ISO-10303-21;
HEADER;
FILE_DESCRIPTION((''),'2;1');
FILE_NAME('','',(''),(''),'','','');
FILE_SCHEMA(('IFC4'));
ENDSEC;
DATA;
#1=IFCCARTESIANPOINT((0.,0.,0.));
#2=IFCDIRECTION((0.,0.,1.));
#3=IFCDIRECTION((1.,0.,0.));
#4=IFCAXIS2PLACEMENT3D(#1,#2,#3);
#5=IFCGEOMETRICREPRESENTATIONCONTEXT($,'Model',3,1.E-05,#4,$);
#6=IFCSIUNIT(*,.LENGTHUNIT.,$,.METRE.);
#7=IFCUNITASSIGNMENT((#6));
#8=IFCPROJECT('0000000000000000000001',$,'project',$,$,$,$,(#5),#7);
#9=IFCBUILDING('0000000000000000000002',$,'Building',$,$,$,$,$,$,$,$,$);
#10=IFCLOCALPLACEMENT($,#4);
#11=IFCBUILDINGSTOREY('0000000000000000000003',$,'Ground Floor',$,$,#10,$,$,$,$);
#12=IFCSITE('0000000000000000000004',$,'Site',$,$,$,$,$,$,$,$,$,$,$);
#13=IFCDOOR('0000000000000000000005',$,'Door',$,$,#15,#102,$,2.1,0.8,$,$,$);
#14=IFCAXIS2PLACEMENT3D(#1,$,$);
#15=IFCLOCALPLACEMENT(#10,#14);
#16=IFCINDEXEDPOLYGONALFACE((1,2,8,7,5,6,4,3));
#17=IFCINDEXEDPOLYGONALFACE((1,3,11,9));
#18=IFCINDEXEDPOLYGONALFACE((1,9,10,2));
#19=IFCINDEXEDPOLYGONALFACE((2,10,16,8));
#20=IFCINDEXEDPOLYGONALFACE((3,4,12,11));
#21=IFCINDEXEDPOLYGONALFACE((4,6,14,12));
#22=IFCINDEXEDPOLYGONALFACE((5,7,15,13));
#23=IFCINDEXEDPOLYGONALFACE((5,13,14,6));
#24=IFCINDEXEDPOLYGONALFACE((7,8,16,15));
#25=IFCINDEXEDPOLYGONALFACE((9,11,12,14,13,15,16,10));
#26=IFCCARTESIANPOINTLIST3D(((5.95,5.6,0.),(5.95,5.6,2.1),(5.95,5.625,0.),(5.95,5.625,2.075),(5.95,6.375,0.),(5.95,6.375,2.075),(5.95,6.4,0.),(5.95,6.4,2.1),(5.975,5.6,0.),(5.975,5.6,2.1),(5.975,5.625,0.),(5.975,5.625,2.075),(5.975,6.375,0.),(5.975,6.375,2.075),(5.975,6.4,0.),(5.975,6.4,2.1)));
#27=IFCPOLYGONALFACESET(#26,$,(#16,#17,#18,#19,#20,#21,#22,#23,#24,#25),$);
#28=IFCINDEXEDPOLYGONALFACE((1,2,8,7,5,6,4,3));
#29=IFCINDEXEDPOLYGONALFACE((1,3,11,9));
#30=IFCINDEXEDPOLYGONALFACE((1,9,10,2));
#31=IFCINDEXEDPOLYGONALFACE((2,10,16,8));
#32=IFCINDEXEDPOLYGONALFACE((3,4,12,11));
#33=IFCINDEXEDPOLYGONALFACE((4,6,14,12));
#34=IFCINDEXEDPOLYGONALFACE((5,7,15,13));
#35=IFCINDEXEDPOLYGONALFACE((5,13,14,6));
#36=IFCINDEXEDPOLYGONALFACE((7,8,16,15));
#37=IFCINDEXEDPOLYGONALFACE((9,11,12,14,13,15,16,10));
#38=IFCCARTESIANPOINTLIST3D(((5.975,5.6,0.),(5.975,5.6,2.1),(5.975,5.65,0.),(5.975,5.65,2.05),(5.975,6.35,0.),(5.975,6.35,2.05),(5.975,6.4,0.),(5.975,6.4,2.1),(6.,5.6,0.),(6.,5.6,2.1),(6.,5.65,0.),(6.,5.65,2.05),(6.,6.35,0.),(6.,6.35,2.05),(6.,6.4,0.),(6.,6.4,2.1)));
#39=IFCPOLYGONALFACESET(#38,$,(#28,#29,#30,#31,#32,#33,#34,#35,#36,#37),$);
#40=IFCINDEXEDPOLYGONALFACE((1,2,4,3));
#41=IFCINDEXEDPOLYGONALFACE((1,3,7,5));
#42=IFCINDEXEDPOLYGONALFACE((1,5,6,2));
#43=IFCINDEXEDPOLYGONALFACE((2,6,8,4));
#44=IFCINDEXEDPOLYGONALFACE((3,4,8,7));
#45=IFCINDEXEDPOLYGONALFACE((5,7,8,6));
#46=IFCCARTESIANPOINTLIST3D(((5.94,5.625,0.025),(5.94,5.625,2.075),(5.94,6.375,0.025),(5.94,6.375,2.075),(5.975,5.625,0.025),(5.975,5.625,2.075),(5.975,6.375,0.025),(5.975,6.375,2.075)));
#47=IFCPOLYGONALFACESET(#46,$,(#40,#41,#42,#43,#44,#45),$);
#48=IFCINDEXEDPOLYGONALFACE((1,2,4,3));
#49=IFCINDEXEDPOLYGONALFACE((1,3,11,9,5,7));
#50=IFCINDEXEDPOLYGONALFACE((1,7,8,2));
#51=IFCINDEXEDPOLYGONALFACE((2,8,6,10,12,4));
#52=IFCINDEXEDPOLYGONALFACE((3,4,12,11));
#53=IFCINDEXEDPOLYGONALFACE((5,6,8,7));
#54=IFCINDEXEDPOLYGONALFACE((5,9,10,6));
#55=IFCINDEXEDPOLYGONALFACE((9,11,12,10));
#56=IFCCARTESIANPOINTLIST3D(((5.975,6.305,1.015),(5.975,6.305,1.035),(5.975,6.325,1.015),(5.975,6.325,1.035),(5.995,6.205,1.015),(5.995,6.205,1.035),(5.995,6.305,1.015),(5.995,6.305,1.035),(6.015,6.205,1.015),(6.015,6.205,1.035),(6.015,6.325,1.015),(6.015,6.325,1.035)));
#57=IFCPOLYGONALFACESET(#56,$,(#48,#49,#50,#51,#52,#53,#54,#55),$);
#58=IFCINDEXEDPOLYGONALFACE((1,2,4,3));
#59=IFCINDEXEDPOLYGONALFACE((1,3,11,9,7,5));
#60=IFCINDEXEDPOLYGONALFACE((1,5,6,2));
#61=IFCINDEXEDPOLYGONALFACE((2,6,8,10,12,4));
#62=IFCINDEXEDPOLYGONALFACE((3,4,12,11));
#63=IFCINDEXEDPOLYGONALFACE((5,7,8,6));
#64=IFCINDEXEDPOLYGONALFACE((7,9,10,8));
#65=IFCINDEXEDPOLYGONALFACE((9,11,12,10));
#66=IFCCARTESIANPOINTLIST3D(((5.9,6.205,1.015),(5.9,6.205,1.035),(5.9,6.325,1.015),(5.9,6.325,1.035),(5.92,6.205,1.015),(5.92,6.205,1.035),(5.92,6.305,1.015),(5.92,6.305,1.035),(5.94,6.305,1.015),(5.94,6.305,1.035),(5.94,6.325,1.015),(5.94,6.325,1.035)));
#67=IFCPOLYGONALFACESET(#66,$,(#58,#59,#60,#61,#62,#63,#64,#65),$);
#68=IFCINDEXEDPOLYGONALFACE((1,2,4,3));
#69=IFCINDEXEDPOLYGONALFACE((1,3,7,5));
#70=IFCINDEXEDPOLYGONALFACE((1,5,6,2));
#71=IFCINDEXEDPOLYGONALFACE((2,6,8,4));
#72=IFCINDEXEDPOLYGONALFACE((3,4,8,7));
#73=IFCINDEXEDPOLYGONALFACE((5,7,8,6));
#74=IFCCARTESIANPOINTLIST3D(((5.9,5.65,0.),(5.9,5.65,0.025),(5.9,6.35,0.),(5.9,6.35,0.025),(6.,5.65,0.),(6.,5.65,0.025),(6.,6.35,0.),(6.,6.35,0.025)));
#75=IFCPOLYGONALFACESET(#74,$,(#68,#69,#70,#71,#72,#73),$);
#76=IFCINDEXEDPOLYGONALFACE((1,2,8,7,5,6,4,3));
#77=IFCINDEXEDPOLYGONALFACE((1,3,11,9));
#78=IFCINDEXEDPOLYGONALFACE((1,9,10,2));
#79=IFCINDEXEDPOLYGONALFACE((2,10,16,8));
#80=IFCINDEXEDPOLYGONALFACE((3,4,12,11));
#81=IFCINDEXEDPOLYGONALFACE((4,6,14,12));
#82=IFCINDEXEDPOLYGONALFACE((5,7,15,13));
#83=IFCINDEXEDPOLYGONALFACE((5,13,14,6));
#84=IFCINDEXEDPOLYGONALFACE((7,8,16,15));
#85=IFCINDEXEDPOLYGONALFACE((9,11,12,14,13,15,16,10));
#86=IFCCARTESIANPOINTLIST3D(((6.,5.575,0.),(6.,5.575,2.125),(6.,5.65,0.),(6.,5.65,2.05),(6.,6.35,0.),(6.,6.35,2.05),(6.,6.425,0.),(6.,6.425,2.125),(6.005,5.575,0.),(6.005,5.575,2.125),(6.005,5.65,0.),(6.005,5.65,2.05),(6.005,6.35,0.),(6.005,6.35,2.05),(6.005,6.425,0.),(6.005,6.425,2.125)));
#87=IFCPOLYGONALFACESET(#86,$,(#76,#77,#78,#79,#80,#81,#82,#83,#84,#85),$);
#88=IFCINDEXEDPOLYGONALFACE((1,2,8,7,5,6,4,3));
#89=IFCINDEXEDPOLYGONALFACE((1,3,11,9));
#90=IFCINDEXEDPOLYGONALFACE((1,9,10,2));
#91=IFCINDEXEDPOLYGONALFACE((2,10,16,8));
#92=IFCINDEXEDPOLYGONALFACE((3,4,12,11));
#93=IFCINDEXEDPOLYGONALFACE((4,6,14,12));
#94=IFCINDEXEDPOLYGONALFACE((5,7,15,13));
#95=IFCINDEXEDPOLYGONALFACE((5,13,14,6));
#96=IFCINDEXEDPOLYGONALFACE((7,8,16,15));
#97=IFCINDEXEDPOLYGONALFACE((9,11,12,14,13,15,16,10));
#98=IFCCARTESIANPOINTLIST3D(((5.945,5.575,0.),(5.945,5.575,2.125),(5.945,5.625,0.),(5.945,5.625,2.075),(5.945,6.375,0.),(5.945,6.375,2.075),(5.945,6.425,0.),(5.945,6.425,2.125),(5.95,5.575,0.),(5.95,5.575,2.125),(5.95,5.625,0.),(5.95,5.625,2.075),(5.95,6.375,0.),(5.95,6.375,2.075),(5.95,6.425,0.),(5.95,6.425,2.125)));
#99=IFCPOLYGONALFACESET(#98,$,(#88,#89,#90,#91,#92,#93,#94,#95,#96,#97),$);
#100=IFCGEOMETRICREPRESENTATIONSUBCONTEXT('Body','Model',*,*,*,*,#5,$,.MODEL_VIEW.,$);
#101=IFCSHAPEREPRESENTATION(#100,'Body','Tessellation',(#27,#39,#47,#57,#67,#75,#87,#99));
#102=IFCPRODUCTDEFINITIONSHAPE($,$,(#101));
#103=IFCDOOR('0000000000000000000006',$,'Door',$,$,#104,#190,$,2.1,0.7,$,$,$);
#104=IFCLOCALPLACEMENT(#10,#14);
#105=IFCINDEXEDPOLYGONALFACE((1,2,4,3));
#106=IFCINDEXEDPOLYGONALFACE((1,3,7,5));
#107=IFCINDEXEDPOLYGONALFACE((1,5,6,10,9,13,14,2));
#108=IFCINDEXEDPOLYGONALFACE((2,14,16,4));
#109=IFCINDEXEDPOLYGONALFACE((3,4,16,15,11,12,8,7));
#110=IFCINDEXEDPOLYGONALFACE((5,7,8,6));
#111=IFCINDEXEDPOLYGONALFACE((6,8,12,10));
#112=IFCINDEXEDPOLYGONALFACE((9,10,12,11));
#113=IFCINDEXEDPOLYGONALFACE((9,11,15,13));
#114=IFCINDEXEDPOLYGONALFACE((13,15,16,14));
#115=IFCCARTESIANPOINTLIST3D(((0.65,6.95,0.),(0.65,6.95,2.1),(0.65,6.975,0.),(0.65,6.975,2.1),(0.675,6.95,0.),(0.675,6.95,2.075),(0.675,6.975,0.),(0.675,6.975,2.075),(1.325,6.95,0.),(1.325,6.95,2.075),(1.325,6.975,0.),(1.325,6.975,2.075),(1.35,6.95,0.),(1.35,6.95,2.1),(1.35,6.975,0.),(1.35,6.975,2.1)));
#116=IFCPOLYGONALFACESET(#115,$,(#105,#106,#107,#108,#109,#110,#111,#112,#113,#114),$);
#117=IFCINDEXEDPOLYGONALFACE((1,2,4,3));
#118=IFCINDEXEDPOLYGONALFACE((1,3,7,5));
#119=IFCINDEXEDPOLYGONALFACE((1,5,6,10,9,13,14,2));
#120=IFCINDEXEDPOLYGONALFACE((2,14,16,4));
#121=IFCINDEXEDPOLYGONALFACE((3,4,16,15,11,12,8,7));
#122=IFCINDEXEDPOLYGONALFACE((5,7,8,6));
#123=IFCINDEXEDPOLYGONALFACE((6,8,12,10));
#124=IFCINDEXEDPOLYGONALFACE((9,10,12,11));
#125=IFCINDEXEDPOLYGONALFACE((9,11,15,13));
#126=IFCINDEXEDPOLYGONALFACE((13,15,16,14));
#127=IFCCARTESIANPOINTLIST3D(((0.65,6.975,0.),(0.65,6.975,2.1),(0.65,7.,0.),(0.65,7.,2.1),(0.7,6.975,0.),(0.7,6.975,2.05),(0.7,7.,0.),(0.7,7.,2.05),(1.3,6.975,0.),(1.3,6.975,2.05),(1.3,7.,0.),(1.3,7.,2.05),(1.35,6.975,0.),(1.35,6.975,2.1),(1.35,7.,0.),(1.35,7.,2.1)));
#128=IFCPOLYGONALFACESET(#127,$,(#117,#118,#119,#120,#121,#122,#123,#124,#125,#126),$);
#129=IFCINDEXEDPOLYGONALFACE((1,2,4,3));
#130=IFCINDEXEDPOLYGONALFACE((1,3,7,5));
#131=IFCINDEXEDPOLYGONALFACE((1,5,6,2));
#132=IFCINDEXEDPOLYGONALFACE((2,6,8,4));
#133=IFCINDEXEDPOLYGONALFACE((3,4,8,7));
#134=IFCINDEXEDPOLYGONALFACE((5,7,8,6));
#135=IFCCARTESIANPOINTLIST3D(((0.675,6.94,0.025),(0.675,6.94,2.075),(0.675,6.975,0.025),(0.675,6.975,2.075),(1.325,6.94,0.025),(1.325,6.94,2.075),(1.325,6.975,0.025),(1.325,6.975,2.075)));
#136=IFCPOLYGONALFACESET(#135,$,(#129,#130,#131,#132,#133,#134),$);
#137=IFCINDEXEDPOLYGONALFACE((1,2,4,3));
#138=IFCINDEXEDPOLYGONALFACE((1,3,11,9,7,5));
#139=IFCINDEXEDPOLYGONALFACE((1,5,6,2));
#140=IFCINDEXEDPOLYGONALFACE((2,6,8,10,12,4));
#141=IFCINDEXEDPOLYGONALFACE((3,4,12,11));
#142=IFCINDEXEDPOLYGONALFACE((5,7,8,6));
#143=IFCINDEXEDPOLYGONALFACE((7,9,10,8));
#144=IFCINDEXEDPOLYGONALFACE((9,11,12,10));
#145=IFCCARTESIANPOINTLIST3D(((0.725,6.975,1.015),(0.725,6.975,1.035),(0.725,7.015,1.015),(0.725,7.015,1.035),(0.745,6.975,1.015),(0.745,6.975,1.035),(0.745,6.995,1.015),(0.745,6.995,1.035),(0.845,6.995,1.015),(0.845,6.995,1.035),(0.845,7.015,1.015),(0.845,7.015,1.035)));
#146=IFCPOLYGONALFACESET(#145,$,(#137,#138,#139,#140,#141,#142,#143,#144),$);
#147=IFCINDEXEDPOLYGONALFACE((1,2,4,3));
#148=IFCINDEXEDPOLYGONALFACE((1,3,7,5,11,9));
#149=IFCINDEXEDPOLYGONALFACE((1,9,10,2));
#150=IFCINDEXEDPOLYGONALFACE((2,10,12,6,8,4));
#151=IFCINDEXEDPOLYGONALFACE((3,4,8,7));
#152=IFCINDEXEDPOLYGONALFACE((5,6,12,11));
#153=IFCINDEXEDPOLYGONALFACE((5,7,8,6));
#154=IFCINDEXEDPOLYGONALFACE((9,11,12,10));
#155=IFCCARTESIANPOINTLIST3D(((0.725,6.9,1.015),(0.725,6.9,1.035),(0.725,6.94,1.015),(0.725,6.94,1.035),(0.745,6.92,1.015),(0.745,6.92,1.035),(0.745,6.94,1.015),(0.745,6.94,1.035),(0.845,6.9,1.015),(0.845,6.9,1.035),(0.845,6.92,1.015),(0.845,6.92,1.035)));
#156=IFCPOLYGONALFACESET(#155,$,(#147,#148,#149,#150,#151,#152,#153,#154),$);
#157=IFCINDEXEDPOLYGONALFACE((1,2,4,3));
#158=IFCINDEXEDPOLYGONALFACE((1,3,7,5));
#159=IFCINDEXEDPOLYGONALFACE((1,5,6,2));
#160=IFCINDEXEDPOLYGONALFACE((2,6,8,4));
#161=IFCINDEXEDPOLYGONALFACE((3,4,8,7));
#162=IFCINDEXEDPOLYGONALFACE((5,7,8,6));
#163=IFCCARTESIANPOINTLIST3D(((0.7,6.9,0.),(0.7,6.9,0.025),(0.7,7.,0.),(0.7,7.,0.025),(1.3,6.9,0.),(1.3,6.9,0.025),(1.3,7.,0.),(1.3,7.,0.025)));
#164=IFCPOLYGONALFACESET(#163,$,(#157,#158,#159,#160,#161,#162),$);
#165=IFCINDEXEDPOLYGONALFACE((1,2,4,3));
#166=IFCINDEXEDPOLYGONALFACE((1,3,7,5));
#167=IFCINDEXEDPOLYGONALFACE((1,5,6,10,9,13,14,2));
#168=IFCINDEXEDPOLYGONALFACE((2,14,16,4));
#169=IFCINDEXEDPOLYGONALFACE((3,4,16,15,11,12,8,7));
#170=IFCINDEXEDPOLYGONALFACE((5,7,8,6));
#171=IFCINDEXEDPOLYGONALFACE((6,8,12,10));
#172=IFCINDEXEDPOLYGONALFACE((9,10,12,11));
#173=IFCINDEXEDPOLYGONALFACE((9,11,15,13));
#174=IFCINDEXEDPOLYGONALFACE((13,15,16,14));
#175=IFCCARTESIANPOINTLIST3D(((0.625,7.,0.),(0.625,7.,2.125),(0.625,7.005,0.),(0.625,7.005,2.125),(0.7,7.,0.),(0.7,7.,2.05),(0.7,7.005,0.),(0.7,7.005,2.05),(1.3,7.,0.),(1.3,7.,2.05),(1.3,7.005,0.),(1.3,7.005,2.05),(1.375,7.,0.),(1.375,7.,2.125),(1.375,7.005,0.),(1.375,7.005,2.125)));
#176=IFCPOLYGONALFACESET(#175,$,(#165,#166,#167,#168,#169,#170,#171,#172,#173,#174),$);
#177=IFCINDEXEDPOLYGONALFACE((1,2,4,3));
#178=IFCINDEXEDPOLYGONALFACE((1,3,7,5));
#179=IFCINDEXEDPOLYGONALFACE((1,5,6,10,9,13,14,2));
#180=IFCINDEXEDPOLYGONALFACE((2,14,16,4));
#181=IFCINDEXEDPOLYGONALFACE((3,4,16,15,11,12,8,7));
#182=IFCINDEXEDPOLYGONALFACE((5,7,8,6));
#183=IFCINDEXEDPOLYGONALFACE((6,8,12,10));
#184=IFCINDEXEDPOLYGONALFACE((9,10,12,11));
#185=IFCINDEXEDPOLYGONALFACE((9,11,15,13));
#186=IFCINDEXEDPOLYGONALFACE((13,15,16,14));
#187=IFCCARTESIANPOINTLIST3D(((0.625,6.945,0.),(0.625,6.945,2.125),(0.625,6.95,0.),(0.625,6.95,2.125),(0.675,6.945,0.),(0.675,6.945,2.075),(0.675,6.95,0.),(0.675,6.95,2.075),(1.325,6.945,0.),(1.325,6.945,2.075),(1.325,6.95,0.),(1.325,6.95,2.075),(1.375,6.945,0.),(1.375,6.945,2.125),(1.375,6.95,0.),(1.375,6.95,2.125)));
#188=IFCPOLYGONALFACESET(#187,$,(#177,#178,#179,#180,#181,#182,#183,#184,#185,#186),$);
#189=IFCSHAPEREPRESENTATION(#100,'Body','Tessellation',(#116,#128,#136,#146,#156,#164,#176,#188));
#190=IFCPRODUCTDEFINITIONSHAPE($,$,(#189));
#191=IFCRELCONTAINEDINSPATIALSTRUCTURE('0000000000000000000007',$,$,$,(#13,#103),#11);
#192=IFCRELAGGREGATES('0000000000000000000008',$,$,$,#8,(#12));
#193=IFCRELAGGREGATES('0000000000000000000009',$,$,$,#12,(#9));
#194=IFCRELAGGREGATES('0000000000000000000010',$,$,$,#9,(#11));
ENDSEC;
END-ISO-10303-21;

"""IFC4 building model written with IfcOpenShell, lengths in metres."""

from ifc_helpers import new_model, si_unit, frame, origin_with_axes, place, context, subcontext, project, spatial, line, indexed_curve, outline, extrude, element, save


model = new_model("IFC4")

# Units and contexts
model_context = context("Model", 3, precision=1e-05, world=origin_with_axes())
body_context = subcontext(model_context, "Body", "Model", "MODEL_VIEW")
ifc_project = project(units=[si_unit("LENGTHUNIT", "METRE")], contexts=[model_context])

# Site, building, storey
site = spatial("IfcSite", under=ifc_project, Name="Site")
building = spatial("IfcBuilding", under=site, Name="Building")
storey_placement = place(None, origin_with_axes())
storey = spatial("IfcBuildingStorey", under=building, at=storey_placement, Name="Ground Floor")

# Doors
door_1_placement = place(storey_placement, frame((6.0, 5.6, 0.0), z_axis=(0.0, 0.0, 1.0), x_axis=(0.0, 1.0, 0.0)))
element("IfcDoor", 1, at=door_1_placement, inside=storey, Name="Door", OverallHeight=2.1, OverallWidth=0.8, context=body_context, shape_type="SweptSolid", body=[
    extrude(outline(indexed_curve([(0.0, 0.0), (0.0, 2.1), (0.8, 2.1), (0.8, 0.0), (0.775, 0.0), (0.775, 2.075), (0.025, 2.075), (0.025, 0.0)], segments=[line(1, 2, 3, 4, 5, 6, 7, 8, 1)])), frame((0.0, 0.025, 0.0), z_axis=(0.0, -1.0, 0.0), x_axis=(1.0, 0.0, 0.0)), (0.0, 0.0, -1.0), 0.025),
    extrude(outline(indexed_curve([(0.0, 0.0), (0.0, 2.1), (0.8, 2.1), (0.8, 0.0), (0.75, 0.0), (0.75, 2.05), (0.05, 2.05), (0.05, 0.0)], segments=[line(1, 2, 3, 4, 5, 6, 7, 8, 1)])), frame((0.0, 0.0, 0.0), z_axis=(0.0, -1.0, 0.0), x_axis=(1.0, 0.0, 0.0)), (0.0, 0.0, -1.0), 0.025),
    extrude(outline(indexed_curve([(0.0, 0.0), (0.75, 0.0), (0.75, 0.035), (0.0, 0.035)], segments=[line(1, 2, 3, 4, 1)])), frame((0.025, 0.025, 0.025), z_axis=(0.0, 0.0, 1.0), x_axis=(1.0, 0.0, 0.0)), (0.0, 0.0, 1.0), 2.05),
    extrude(outline(indexed_curve([(0.0, 0.0), (0.0, -0.04), (-0.12, -0.04), (-0.12, -0.02), (-0.02, -0.02), (-0.02, 0.0)], segments=[line(1, 2, 3, 4, 5, 6, 1)])), frame((0.725, 0.025, 1.015), z_axis=(0.0, 0.0, 1.0), x_axis=(1.0, 0.0, 0.0)), (0.0, 0.0, 1.0), 0.02),
    extrude(outline(indexed_curve([(0.0, 0.0), (0.0, 0.04), (-0.12, 0.04), (-0.12, 0.02), (-0.02, 0.02), (-0.02, 0.0)], segments=[line(1, 2, 3, 4, 5, 6, 1)])), frame((0.725, 0.06, 1.015), z_axis=(0.0, 0.0, 1.0), x_axis=(1.0, 0.0, 0.0)), (0.0, 0.0, 1.0), 0.02),
    extrude(outline(indexed_curve([(0.0, 0.0), (0.7, 0.0), (0.7, 0.1), (0.0, 0.1)], segments=[line(1, 2, 3, 4, 1)])), frame((0.05, 0.0, 0.0), z_axis=(0.0, 0.0, 1.0), x_axis=(1.0, 0.0, 0.0)), (0.0, 0.0, 1.0), 0.025),
    extrude(outline(indexed_curve([(0.0, 0.0), (0.0, 2.125), (0.85, 2.125), (0.85, 0.0), (0.775, 0.0), (0.775, 2.05), (0.075, 2.05), (0.075, 0.0)], segments=[line(1, 2, 3, 4, 5, 6, 7, 8, 1)])), frame((-0.025, -0.005, 0.0), z_axis=(0.0, -1.0, 0.0), x_axis=(1.0, 0.0, 0.0)), (0.0, 0.0, -1.0), 0.005),
    extrude(outline(indexed_curve([(0.0, 0.0), (0.0, 2.125), (0.85, 2.125), (0.85, 0.0), (0.8, 0.0), (0.8, 2.075), (0.05, 2.075), (0.05, 0.0)], segments=[line(1, 2, 3, 4, 5, 6, 7, 8, 1)])), frame((-0.025, 0.05, 0.0), z_axis=(0.0, -1.0, 0.0), x_axis=(1.0, 0.0, 0.0)), (0.0, 0.0, -1.0), 0.005),
])
door_2_placement = place(storey_placement, frame((1.35, 7.0, 0.0), z_axis=(0.0, 0.0, 1.0), x_axis=(-1.0, 0.0, 0.0)))
element("IfcDoor", 2, at=door_2_placement, inside=storey, Name="Door", OverallHeight=2.1, OverallWidth=0.7, context=body_context, shape_type="SweptSolid", body=[
    extrude(outline(indexed_curve([(0.0, 0.0), (0.0, 2.1), (0.7, 2.1), (0.7, 0.0), (0.675, 0.0), (0.675, 2.075), (0.025, 2.075), (0.025, 0.0)], segments=[line(1, 2, 3, 4, 5, 6, 7, 8, 1)])), frame((0.0, 0.025, 0.0), z_axis=(0.0, -1.0, 0.0), x_axis=(1.0, 0.0, 0.0)), (0.0, 0.0, -1.0), 0.025),
    extrude(outline(indexed_curve([(0.0, 0.0), (0.0, 2.1), (0.7, 2.1), (0.7, 0.0), (0.65, 0.0), (0.65, 2.05), (0.05, 2.05), (0.05, 0.0)], segments=[line(1, 2, 3, 4, 5, 6, 7, 8, 1)])), frame((0.0, 0.0, 0.0), z_axis=(0.0, -1.0, 0.0), x_axis=(1.0, 0.0, 0.0)), (0.0, 0.0, -1.0), 0.025),
    extrude(outline(indexed_curve([(0.0, 0.0), (0.65, 0.0), (0.65, 0.035), (0.0, 0.035)], segments=[line(1, 2, 3, 4, 1)])), frame((0.025, 0.025, 0.025), z_axis=(0.0, 0.0, 1.0), x_axis=(1.0, 0.0, 0.0)), (0.0, 0.0, 1.0), 2.05),
    extrude(outline(indexed_curve([(0.0, 0.0), (0.0, -0.04), (-0.12, -0.04), (-0.12, -0.02), (-0.02, -0.02), (-0.02, 0.0)], segments=[line(1, 2, 3, 4, 5, 6, 1)])), frame((0.625, 0.025, 1.015), z_axis=(0.0, 0.0, 1.0), x_axis=(1.0, 0.0, 0.0)), (0.0, 0.0, 1.0), 0.02),
    extrude(outline(indexed_curve([(0.0, 0.0), (0.0, 0.04), (-0.12, 0.04), (-0.12, 0.02), (-0.02, 0.02), (-0.02, 0.0)], segments=[line(1, 2, 3, 4, 5, 6, 1)])), frame((0.625, 0.06, 1.015), z_axis=(0.0, 0.0, 1.0), x_axis=(1.0, 0.0, 0.0)), (0.0, 0.0, 1.0), 0.02),
    extrude(outline(indexed_curve([(0.0, 0.0), (0.6, 0.0), (0.6, 0.1), (0.0, 0.1)], segments=[line(1, 2, 3, 4, 1)])), frame((0.05, 0.0, 0.0), z_axis=(0.0, 0.0, 1.0), x_axis=(1.0, 0.0, 0.0)), (0.0, 0.0, 1.0), 0.025),
    extrude(outline(indexed_curve([(0.0, 0.0), (0.0, 2.125), (0.75, 2.125), (0.75, 0.0), (0.675, 0.0), (0.675, 2.05), (0.075, 2.05), (0.075, 0.0)], segments=[line(1, 2, 3, 4, 5, 6, 7, 8, 1)])), frame((-0.025, -0.005, 0.0), z_axis=(0.0, -1.0, 0.0), x_axis=(1.0, 0.0, 0.0)), (0.0, 0.0, -1.0), 0.005),
    extrude(outline(indexed_curve([(0.0, 0.0), (0.0, 2.125), (0.75, 2.125), (0.75, 0.0), (0.7, 0.0), (0.7, 2.075), (0.05, 2.075), (0.05, 0.0)], segments=[line(1, 2, 3, 4, 5, 6, 7, 8, 1)])), frame((-0.025, 0.05, 0.0), z_axis=(0.0, -1.0, 0.0), x_axis=(1.0, 0.0, 0.0)), (0.0, 0.0, -1.0), 0.005),
])

save(model, "model.ifc")
